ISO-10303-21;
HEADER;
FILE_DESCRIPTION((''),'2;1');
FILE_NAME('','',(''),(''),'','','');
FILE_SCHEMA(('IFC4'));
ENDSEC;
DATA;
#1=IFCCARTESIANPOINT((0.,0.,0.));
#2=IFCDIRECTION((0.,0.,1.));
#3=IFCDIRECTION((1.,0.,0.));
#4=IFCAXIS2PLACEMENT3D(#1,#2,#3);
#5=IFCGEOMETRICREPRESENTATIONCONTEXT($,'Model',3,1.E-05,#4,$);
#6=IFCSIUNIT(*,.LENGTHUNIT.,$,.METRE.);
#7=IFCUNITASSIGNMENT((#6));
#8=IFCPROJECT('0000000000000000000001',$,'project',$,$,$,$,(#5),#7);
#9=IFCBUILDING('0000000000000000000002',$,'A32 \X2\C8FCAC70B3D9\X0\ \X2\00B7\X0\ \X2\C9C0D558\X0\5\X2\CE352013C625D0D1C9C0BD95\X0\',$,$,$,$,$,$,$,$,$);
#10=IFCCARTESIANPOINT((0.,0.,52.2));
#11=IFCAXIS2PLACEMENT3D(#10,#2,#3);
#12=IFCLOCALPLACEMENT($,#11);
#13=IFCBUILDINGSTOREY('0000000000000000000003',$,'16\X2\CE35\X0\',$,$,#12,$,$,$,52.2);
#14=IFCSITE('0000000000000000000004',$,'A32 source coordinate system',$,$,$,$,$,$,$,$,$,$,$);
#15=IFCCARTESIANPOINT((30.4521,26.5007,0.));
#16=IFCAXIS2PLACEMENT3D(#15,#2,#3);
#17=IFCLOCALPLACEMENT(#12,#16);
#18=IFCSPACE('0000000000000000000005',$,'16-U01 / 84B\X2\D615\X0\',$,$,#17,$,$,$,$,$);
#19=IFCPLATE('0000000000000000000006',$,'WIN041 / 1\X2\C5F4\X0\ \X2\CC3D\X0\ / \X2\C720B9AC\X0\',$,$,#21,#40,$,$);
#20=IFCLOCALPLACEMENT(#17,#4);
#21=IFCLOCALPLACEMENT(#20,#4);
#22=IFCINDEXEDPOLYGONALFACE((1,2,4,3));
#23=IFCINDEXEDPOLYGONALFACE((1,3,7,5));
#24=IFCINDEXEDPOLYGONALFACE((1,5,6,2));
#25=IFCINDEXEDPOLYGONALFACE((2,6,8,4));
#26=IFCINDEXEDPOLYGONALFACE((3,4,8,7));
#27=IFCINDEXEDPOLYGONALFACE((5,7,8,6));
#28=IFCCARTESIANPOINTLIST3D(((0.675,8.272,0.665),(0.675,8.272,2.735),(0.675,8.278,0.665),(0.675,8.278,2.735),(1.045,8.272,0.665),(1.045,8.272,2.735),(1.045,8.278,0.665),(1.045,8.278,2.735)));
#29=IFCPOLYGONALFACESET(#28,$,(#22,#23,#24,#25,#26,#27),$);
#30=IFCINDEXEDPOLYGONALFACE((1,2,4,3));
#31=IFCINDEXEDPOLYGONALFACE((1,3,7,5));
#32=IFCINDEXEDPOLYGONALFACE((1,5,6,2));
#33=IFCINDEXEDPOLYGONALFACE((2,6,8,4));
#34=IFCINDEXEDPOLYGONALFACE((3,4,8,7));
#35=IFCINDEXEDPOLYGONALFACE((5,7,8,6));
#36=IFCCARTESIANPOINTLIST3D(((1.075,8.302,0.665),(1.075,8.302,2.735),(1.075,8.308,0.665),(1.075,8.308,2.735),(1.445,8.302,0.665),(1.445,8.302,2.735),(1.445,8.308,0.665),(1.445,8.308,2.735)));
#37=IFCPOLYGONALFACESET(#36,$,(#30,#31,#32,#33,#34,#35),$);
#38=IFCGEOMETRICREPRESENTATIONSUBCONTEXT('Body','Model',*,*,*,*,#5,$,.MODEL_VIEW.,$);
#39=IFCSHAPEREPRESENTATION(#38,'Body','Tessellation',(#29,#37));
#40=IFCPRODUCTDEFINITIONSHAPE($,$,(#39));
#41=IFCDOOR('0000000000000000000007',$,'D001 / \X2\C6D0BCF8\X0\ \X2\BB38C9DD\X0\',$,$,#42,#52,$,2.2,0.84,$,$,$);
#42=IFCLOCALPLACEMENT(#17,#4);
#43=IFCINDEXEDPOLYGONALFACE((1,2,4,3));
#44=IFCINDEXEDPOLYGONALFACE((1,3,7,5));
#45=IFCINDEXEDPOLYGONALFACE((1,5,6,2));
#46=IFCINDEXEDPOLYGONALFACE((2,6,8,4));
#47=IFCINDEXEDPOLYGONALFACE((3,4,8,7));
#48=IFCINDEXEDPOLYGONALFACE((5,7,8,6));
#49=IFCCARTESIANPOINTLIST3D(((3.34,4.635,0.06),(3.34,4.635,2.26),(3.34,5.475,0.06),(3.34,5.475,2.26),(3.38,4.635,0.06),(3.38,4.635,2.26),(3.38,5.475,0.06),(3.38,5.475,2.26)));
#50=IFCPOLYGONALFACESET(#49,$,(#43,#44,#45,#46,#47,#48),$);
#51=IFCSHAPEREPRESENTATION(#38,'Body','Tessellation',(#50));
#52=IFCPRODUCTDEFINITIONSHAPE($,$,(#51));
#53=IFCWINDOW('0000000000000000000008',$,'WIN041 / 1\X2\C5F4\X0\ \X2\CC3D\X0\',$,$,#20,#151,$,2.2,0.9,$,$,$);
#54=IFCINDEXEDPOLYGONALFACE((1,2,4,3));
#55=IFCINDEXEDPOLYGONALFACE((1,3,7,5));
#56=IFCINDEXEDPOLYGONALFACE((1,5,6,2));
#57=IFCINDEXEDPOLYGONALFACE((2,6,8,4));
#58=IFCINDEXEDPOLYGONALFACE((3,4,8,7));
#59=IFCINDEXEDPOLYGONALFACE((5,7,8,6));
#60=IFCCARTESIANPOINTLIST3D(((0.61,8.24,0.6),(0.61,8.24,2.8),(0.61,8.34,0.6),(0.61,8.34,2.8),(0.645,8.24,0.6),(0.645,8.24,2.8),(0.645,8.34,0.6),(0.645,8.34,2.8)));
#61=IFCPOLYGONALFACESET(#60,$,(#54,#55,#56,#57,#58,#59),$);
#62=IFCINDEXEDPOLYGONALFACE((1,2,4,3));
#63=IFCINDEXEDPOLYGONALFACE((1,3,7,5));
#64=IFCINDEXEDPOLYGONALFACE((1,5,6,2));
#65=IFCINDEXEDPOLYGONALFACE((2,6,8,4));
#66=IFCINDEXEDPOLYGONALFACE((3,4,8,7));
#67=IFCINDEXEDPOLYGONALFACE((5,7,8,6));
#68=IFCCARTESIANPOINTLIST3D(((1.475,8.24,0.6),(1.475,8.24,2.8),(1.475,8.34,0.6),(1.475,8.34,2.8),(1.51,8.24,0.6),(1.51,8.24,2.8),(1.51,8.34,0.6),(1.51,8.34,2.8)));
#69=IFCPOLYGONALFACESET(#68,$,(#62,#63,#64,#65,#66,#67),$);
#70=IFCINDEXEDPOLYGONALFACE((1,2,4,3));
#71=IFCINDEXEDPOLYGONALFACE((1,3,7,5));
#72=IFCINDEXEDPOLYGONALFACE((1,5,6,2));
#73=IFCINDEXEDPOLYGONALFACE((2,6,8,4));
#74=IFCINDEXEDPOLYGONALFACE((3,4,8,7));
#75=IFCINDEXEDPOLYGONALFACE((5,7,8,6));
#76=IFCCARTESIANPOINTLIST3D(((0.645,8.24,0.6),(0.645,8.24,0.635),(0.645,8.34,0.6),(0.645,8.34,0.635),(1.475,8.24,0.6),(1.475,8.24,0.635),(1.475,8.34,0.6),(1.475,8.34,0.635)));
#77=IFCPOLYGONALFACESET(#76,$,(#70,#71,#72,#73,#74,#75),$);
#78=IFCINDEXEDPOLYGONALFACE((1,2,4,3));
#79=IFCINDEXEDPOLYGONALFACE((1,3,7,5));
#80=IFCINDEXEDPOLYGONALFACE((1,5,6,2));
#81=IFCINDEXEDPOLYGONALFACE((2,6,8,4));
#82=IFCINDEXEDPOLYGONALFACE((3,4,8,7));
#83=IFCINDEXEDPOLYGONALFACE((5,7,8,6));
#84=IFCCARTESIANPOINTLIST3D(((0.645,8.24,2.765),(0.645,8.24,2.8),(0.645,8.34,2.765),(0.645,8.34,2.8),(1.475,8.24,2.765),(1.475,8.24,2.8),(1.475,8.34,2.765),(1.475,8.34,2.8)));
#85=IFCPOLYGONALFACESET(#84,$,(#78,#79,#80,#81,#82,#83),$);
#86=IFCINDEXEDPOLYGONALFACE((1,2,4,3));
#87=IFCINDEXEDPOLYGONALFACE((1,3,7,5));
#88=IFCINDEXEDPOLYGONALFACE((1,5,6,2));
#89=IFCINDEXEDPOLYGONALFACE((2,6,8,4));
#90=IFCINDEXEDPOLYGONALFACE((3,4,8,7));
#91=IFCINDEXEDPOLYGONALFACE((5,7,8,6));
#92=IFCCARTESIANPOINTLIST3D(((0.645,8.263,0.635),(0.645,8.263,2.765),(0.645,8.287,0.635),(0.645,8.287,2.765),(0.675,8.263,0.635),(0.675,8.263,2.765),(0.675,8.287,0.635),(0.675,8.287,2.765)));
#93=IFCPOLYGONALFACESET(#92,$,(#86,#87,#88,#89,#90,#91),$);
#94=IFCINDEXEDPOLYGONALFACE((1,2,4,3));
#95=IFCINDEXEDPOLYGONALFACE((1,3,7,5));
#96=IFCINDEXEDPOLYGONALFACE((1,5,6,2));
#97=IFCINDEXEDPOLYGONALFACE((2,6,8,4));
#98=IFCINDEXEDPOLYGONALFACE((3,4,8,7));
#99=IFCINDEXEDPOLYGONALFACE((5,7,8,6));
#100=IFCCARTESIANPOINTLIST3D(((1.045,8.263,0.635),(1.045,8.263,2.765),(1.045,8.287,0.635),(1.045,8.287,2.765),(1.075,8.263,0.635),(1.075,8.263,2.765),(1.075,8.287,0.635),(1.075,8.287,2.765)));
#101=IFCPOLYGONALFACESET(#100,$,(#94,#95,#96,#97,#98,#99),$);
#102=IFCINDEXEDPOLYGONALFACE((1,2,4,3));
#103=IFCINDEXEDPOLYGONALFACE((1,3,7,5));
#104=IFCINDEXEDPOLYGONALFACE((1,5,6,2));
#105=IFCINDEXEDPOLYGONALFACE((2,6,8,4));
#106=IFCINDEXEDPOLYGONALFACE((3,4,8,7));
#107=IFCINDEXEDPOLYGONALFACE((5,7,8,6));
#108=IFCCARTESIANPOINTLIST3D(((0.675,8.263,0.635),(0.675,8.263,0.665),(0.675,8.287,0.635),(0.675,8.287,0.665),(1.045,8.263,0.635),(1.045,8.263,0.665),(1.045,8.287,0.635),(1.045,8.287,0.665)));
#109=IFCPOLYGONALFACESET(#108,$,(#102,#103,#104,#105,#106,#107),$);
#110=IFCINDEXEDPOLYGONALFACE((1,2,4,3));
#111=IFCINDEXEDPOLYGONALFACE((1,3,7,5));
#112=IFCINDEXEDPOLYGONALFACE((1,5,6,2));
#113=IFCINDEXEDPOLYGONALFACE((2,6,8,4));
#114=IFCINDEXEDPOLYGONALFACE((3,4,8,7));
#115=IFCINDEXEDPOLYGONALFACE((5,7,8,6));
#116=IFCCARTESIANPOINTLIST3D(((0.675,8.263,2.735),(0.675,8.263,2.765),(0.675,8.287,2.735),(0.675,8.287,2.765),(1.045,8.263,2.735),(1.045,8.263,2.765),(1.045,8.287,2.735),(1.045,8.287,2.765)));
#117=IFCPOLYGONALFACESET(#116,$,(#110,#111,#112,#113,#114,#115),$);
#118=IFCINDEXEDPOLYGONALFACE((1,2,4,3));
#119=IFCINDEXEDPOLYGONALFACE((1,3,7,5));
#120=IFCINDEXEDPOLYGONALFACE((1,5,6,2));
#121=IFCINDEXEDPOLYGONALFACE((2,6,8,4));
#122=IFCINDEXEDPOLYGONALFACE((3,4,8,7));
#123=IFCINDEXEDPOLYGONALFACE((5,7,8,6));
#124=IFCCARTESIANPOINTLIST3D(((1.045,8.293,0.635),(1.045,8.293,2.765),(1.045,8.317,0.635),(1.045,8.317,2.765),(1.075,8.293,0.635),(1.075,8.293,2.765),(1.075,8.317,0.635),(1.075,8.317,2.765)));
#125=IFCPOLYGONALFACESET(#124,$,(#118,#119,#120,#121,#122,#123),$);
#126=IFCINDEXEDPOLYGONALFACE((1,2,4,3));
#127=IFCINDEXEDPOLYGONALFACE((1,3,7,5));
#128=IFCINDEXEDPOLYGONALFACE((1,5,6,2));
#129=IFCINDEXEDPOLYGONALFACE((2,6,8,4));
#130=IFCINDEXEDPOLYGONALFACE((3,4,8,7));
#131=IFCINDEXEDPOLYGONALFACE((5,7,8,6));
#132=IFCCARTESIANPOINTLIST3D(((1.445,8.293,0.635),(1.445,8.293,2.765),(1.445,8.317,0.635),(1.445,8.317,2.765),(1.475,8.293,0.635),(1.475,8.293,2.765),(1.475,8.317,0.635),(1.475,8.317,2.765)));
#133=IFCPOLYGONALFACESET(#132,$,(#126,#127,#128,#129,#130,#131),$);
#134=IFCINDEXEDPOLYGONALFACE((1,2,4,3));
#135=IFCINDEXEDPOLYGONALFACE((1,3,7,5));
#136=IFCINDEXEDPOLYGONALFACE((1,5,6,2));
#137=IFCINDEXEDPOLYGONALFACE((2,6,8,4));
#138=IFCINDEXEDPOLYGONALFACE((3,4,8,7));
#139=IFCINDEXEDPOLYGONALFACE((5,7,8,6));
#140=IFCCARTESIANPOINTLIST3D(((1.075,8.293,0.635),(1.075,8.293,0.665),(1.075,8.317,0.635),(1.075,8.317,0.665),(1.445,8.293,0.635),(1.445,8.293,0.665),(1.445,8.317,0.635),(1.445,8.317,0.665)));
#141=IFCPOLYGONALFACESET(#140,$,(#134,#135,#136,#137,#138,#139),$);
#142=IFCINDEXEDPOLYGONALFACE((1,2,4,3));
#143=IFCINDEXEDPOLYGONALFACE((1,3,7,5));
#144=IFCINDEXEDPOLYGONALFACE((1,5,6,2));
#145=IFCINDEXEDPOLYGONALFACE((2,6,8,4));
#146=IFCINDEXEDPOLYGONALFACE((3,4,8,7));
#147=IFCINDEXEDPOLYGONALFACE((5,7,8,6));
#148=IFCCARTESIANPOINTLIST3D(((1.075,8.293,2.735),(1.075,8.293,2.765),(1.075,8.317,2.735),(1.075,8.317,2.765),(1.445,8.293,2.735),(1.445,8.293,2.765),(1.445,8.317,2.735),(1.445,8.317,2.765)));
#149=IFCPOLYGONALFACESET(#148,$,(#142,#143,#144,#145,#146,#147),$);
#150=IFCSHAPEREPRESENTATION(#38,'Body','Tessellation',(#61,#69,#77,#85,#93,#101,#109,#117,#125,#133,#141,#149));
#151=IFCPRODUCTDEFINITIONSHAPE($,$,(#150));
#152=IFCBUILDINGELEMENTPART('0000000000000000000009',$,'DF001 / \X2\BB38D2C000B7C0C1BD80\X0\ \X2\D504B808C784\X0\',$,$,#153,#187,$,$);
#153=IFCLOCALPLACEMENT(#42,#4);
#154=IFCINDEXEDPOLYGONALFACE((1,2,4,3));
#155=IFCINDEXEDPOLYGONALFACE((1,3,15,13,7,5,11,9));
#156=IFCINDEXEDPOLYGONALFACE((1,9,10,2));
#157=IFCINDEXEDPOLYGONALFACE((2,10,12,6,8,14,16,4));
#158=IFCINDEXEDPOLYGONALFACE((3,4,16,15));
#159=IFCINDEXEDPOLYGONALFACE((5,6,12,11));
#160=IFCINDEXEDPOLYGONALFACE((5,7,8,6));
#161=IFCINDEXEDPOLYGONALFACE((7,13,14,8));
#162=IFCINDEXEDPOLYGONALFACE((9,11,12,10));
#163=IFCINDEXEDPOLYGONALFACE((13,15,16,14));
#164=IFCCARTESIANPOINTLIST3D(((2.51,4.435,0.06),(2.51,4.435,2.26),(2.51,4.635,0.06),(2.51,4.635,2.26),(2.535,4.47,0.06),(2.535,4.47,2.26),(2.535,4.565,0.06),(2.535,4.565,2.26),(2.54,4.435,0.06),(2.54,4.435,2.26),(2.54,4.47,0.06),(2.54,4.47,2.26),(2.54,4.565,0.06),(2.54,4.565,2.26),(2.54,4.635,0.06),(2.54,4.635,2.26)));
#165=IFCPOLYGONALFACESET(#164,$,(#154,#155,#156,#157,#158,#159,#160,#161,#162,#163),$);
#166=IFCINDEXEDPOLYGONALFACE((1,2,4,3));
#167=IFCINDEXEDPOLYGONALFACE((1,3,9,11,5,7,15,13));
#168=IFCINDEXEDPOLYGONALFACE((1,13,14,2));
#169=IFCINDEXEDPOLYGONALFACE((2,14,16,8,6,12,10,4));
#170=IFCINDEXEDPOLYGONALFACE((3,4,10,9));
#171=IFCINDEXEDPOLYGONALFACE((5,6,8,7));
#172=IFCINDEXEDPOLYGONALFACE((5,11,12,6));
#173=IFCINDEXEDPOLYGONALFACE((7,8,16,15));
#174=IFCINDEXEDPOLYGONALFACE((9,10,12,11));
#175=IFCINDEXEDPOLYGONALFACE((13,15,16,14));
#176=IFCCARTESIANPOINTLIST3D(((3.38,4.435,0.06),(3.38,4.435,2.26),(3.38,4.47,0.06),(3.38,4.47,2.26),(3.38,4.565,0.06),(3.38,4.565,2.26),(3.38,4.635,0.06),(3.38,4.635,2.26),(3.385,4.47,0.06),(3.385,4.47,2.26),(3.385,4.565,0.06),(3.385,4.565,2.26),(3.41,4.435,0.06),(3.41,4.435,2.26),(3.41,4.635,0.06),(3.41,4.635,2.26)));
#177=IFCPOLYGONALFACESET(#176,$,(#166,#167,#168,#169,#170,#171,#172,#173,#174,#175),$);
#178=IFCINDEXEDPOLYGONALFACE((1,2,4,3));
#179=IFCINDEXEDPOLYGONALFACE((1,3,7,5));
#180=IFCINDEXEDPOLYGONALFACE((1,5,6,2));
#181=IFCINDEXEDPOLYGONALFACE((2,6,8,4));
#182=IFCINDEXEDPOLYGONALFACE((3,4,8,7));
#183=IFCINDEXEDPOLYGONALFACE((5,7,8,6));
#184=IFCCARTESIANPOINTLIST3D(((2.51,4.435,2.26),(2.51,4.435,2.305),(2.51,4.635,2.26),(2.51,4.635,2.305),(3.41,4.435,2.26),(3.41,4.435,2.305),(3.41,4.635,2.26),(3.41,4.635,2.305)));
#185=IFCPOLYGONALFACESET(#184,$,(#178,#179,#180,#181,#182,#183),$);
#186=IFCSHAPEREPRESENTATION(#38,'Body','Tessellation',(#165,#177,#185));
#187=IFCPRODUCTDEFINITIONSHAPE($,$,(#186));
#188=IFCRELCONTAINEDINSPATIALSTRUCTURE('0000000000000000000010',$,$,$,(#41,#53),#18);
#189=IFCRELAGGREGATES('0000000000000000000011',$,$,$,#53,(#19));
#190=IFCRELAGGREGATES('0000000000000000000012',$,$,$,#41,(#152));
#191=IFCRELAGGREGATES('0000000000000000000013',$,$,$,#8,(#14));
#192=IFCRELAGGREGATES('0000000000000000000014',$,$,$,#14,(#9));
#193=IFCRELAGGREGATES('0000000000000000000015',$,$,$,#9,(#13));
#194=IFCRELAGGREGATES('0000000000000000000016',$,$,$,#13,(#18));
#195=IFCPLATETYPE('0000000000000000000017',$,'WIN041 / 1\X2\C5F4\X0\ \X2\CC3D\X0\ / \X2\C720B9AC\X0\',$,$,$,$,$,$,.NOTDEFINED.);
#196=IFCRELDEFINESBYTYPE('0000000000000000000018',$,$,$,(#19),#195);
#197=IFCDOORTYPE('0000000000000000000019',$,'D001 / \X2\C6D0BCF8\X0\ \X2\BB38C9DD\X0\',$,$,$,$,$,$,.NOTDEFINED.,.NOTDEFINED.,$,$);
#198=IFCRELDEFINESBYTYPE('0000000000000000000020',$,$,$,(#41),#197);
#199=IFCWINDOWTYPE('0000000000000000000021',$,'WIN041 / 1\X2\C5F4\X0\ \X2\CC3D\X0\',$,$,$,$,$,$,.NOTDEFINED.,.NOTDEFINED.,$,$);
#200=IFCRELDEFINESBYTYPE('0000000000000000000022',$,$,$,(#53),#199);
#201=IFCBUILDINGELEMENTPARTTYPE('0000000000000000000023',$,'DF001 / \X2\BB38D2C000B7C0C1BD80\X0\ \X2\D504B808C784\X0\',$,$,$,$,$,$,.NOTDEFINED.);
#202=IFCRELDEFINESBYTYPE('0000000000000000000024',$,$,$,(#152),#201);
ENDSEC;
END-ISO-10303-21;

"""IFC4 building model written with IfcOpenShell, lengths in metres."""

from ifc_helpers import new_model, si_unit, frame, origin, origin_with_axes, place, context, subcontext, project, spatial, polyline, outline, extrude, source, transform, mapped, type_object, type_shapes, element, aggregate, save


model = new_model("IFC4")

# Units and contexts
model_context = context("Model", 3, precision=1e-05, world=origin_with_axes())
body_context = subcontext(model_context, "Body", "Model", "MODEL_VIEW")
ifc_project = project(units=[si_unit("LENGTHUNIT", "METRE")], contexts=[model_context])

# Plate
storey_placement = place(None, frame((0.0, 0.0, 52.2), z_axis=(0.0, 0.0, 1.0), x_axis=(1.0, 0.0, 0.0)))
space_placement = place(storey_placement, frame((30.4521, 26.5007, 0.0), z_axis=(0.0, 0.0, 1.0), x_axis=(1.0, 0.0, 0.0)))
plate_type_1 = type_object("IfcPlateType", Name="WIN041 / 1열 창 / 유리", PredefinedType="NOTDEFINED")
shared_shape_1 = source(origin(), body_context, "Body", "SweptSolid", [
    extrude(outline(polyline([(0.675, 8.272), (0.675, 8.278), (1.045, 8.278), (1.045, 8.272), (0.675, 8.272)])), frame((0.0, 0.0, 0.665)), (0.0, 0.0, 1.0), 2.07),
    extrude(outline(polyline([(1.075, 8.302), (1.075, 8.308), (1.445, 8.308), (1.445, 8.302), (1.075, 8.302)])), frame((0.0, 0.0, 0.665)), (0.0, 0.0, 1.0), 2.07),
])
type_shapes(plate_type_1, [shared_shape_1])
window_1_placement = place(space_placement, origin_with_axes())
plate_1_placement = place(window_1_placement, origin_with_axes())
plate_1 = element("IfcPlate", 1, at=plate_1_placement, type_object=plate_type_1, Name="WIN041 / 1열 창 / 유리", context=body_context, shape_type="MappedRepresentation", body=[
    mapped(shared_shape_1, transform((0.0, 0.0, 0.0), scale=1.0)),
])

# Site, building, storey, space
site = spatial("IfcSite", under=ifc_project, Name="A32 source coordinate system")
building = spatial("IfcBuilding", under=site, Name="A32 주거동 · 지하5층–옥탑지붕")
storey = spatial("IfcBuildingStorey", under=building, at=storey_placement, Name="16층", Elevation=52.2)
space = spatial("IfcSpace", under=storey, at=space_placement, Name="16-U01 / 84B형")

# Door
door_type_1 = type_object("IfcDoorType", Name="D001 / 원본 문짝", OperationType="NOTDEFINED", PredefinedType="NOTDEFINED")
shared_shape_2 = source(origin(), body_context, "Body", "SweptSolid", [
    extrude(outline(polyline([(3.34, 5.475), (3.38, 5.475), (3.38, 4.635), (3.34, 4.635), (3.34, 5.475)])), frame((0.0, 0.0, 0.06)), (0.0, 0.0, 1.0), 2.2),
])
type_shapes(door_type_1, [shared_shape_2])
door_1_placement = place(space_placement, origin_with_axes())
door_1 = element("IfcDoor", 2, at=door_1_placement, inside=space, type_object=door_type_1, Name="D001 / 원본 문짝", OverallHeight=2.2, OverallWidth=0.84, context=body_context, shape_type="MappedRepresentation", body=[
    mapped(shared_shape_2, transform((0.0, 0.0, 0.0), scale=1.0)),
])

# Window
window_type_1 = type_object("IfcWindowType", Name="WIN041 / 1열 창", PartitioningType="NOTDEFINED", PredefinedType="NOTDEFINED")
shared_shape_3 = source(origin(), body_context, "Body", "SweptSolid", [
    extrude(outline(polyline([(0.61, 8.24), (0.61, 8.34), (0.645, 8.34), (0.645, 8.24), (0.61, 8.24)])), frame((0.0, 0.0, 0.6)), (0.0, 0.0, 1.0), 2.2),
    extrude(outline(polyline([(1.475, 8.24), (1.475, 8.34), (1.51, 8.34), (1.51, 8.24), (1.475, 8.24)])), frame((0.0, 0.0, 0.6)), (0.0, 0.0, 1.0), 2.2),
    extrude(outline(polyline([(0.645, 8.24), (0.645, 8.34), (1.475, 8.34), (1.475, 8.24), (0.645, 8.24)])), frame((0.0, 0.0, 0.6)), (0.0, 0.0, 1.0), 0.035),
    extrude(outline(polyline([(0.645, 8.24), (0.645, 8.34), (1.475, 8.34), (1.475, 8.24), (0.645, 8.24)])), frame((0.0, 0.0, 2.765)), (0.0, 0.0, 1.0), 0.035),
    extrude(outline(polyline([(0.645, 8.263), (0.645, 8.287), (0.675, 8.287), (0.675, 8.263), (0.645, 8.263)])), frame((0.0, 0.0, 0.635)), (0.0, 0.0, 1.0), 2.13),
    extrude(outline(polyline([(1.045, 8.263), (1.045, 8.287), (1.075, 8.287), (1.075, 8.263), (1.045, 8.263)])), frame((0.0, 0.0, 0.635)), (0.0, 0.0, 1.0), 2.13),
    extrude(outline(polyline([(0.675, 8.263), (0.675, 8.287), (1.045, 8.287), (1.045, 8.263), (0.675, 8.263)])), frame((0.0, 0.0, 0.635)), (0.0, 0.0, 1.0), 0.03),
    extrude(outline(polyline([(0.675, 8.263), (0.675, 8.287), (1.045, 8.287), (1.045, 8.263), (0.675, 8.263)])), frame((0.0, 0.0, 2.735)), (0.0, 0.0, 1.0), 0.03),
    extrude(outline(polyline([(1.045, 8.293), (1.045, 8.317), (1.075, 8.317), (1.075, 8.293), (1.045, 8.293)])), frame((0.0, 0.0, 0.635)), (0.0, 0.0, 1.0), 2.13),
    extrude(outline(polyline([(1.445, 8.293), (1.445, 8.317), (1.475, 8.317), (1.475, 8.293), (1.445, 8.293)])), frame((0.0, 0.0, 0.635)), (0.0, 0.0, 1.0), 2.13),
    extrude(outline(polyline([(1.075, 8.293), (1.075, 8.317), (1.445, 8.317), (1.445, 8.293), (1.075, 8.293)])), frame((0.0, 0.0, 0.635)), (0.0, 0.0, 1.0), 0.03),
    extrude(outline(polyline([(1.075, 8.293), (1.075, 8.317), (1.445, 8.317), (1.445, 8.293), (1.075, 8.293)])), frame((0.0, 0.0, 2.735)), (0.0, 0.0, 1.0), 0.03),
])
type_shapes(window_type_1, [shared_shape_3])
window_1 = element("IfcWindow", 3, at=window_1_placement, inside=space, type_object=window_type_1, Name="WIN041 / 1열 창", OverallHeight=2.2, OverallWidth=0.9, context=body_context, shape_type="MappedRepresentation", body=[
    mapped(shared_shape_3, transform((0.0, 0.0, 0.0), scale=1.0)),
])
aggregate(window_1, [plate_1])

# Building element part
building_element_part_type_1 = type_object("IfcBuildingElementPartType", Name="DF001 / 문틀·상부 프레임", PredefinedType="NOTDEFINED")
shared_shape_4 = source(origin(), body_context, "Body", "SweptSolid", [
    extrude(outline(polyline([(2.54, 4.635), (2.54, 4.565), (2.535, 4.565), (2.535, 4.47), (2.54, 4.47), (2.54, 4.435), (2.51, 4.435), (2.51, 4.635), (2.54, 4.635)])), frame((0.0, 0.0, 0.06)), (0.0, 0.0, 1.0), 2.2),
    extrude(outline(polyline([(3.41, 4.435), (3.38, 4.435), (3.38, 4.47), (3.385, 4.47), (3.385, 4.565), (3.38, 4.565), (3.38, 4.635), (3.41, 4.635), (3.41, 4.435)])), frame((0.0, 0.0, 0.06)), (0.0, 0.0, 1.0), 2.2),
    extrude(outline(polyline([(2.51, 4.435), (2.51, 4.635), (3.41, 4.635), (3.41, 4.435), (2.51, 4.435)])), frame((0.0, 0.0, 2.26)), (0.0, 0.0, 1.0), 0.045),
])
type_shapes(building_element_part_type_1, [shared_shape_4])
building_element_part_1_placement = place(door_1_placement, origin_with_axes())
building_element_part_1 = element("IfcBuildingElementPart", 4, at=building_element_part_1_placement, type_object=building_element_part_type_1, Name="DF001 / 문틀·상부 프레임", context=body_context, shape_type="MappedRepresentation", body=[
    mapped(shared_shape_4, transform((0.0, 0.0, 0.0), scale=1.0)),
])
aggregate(door_1, [building_element_part_1])

save(model, "model.ifc")
